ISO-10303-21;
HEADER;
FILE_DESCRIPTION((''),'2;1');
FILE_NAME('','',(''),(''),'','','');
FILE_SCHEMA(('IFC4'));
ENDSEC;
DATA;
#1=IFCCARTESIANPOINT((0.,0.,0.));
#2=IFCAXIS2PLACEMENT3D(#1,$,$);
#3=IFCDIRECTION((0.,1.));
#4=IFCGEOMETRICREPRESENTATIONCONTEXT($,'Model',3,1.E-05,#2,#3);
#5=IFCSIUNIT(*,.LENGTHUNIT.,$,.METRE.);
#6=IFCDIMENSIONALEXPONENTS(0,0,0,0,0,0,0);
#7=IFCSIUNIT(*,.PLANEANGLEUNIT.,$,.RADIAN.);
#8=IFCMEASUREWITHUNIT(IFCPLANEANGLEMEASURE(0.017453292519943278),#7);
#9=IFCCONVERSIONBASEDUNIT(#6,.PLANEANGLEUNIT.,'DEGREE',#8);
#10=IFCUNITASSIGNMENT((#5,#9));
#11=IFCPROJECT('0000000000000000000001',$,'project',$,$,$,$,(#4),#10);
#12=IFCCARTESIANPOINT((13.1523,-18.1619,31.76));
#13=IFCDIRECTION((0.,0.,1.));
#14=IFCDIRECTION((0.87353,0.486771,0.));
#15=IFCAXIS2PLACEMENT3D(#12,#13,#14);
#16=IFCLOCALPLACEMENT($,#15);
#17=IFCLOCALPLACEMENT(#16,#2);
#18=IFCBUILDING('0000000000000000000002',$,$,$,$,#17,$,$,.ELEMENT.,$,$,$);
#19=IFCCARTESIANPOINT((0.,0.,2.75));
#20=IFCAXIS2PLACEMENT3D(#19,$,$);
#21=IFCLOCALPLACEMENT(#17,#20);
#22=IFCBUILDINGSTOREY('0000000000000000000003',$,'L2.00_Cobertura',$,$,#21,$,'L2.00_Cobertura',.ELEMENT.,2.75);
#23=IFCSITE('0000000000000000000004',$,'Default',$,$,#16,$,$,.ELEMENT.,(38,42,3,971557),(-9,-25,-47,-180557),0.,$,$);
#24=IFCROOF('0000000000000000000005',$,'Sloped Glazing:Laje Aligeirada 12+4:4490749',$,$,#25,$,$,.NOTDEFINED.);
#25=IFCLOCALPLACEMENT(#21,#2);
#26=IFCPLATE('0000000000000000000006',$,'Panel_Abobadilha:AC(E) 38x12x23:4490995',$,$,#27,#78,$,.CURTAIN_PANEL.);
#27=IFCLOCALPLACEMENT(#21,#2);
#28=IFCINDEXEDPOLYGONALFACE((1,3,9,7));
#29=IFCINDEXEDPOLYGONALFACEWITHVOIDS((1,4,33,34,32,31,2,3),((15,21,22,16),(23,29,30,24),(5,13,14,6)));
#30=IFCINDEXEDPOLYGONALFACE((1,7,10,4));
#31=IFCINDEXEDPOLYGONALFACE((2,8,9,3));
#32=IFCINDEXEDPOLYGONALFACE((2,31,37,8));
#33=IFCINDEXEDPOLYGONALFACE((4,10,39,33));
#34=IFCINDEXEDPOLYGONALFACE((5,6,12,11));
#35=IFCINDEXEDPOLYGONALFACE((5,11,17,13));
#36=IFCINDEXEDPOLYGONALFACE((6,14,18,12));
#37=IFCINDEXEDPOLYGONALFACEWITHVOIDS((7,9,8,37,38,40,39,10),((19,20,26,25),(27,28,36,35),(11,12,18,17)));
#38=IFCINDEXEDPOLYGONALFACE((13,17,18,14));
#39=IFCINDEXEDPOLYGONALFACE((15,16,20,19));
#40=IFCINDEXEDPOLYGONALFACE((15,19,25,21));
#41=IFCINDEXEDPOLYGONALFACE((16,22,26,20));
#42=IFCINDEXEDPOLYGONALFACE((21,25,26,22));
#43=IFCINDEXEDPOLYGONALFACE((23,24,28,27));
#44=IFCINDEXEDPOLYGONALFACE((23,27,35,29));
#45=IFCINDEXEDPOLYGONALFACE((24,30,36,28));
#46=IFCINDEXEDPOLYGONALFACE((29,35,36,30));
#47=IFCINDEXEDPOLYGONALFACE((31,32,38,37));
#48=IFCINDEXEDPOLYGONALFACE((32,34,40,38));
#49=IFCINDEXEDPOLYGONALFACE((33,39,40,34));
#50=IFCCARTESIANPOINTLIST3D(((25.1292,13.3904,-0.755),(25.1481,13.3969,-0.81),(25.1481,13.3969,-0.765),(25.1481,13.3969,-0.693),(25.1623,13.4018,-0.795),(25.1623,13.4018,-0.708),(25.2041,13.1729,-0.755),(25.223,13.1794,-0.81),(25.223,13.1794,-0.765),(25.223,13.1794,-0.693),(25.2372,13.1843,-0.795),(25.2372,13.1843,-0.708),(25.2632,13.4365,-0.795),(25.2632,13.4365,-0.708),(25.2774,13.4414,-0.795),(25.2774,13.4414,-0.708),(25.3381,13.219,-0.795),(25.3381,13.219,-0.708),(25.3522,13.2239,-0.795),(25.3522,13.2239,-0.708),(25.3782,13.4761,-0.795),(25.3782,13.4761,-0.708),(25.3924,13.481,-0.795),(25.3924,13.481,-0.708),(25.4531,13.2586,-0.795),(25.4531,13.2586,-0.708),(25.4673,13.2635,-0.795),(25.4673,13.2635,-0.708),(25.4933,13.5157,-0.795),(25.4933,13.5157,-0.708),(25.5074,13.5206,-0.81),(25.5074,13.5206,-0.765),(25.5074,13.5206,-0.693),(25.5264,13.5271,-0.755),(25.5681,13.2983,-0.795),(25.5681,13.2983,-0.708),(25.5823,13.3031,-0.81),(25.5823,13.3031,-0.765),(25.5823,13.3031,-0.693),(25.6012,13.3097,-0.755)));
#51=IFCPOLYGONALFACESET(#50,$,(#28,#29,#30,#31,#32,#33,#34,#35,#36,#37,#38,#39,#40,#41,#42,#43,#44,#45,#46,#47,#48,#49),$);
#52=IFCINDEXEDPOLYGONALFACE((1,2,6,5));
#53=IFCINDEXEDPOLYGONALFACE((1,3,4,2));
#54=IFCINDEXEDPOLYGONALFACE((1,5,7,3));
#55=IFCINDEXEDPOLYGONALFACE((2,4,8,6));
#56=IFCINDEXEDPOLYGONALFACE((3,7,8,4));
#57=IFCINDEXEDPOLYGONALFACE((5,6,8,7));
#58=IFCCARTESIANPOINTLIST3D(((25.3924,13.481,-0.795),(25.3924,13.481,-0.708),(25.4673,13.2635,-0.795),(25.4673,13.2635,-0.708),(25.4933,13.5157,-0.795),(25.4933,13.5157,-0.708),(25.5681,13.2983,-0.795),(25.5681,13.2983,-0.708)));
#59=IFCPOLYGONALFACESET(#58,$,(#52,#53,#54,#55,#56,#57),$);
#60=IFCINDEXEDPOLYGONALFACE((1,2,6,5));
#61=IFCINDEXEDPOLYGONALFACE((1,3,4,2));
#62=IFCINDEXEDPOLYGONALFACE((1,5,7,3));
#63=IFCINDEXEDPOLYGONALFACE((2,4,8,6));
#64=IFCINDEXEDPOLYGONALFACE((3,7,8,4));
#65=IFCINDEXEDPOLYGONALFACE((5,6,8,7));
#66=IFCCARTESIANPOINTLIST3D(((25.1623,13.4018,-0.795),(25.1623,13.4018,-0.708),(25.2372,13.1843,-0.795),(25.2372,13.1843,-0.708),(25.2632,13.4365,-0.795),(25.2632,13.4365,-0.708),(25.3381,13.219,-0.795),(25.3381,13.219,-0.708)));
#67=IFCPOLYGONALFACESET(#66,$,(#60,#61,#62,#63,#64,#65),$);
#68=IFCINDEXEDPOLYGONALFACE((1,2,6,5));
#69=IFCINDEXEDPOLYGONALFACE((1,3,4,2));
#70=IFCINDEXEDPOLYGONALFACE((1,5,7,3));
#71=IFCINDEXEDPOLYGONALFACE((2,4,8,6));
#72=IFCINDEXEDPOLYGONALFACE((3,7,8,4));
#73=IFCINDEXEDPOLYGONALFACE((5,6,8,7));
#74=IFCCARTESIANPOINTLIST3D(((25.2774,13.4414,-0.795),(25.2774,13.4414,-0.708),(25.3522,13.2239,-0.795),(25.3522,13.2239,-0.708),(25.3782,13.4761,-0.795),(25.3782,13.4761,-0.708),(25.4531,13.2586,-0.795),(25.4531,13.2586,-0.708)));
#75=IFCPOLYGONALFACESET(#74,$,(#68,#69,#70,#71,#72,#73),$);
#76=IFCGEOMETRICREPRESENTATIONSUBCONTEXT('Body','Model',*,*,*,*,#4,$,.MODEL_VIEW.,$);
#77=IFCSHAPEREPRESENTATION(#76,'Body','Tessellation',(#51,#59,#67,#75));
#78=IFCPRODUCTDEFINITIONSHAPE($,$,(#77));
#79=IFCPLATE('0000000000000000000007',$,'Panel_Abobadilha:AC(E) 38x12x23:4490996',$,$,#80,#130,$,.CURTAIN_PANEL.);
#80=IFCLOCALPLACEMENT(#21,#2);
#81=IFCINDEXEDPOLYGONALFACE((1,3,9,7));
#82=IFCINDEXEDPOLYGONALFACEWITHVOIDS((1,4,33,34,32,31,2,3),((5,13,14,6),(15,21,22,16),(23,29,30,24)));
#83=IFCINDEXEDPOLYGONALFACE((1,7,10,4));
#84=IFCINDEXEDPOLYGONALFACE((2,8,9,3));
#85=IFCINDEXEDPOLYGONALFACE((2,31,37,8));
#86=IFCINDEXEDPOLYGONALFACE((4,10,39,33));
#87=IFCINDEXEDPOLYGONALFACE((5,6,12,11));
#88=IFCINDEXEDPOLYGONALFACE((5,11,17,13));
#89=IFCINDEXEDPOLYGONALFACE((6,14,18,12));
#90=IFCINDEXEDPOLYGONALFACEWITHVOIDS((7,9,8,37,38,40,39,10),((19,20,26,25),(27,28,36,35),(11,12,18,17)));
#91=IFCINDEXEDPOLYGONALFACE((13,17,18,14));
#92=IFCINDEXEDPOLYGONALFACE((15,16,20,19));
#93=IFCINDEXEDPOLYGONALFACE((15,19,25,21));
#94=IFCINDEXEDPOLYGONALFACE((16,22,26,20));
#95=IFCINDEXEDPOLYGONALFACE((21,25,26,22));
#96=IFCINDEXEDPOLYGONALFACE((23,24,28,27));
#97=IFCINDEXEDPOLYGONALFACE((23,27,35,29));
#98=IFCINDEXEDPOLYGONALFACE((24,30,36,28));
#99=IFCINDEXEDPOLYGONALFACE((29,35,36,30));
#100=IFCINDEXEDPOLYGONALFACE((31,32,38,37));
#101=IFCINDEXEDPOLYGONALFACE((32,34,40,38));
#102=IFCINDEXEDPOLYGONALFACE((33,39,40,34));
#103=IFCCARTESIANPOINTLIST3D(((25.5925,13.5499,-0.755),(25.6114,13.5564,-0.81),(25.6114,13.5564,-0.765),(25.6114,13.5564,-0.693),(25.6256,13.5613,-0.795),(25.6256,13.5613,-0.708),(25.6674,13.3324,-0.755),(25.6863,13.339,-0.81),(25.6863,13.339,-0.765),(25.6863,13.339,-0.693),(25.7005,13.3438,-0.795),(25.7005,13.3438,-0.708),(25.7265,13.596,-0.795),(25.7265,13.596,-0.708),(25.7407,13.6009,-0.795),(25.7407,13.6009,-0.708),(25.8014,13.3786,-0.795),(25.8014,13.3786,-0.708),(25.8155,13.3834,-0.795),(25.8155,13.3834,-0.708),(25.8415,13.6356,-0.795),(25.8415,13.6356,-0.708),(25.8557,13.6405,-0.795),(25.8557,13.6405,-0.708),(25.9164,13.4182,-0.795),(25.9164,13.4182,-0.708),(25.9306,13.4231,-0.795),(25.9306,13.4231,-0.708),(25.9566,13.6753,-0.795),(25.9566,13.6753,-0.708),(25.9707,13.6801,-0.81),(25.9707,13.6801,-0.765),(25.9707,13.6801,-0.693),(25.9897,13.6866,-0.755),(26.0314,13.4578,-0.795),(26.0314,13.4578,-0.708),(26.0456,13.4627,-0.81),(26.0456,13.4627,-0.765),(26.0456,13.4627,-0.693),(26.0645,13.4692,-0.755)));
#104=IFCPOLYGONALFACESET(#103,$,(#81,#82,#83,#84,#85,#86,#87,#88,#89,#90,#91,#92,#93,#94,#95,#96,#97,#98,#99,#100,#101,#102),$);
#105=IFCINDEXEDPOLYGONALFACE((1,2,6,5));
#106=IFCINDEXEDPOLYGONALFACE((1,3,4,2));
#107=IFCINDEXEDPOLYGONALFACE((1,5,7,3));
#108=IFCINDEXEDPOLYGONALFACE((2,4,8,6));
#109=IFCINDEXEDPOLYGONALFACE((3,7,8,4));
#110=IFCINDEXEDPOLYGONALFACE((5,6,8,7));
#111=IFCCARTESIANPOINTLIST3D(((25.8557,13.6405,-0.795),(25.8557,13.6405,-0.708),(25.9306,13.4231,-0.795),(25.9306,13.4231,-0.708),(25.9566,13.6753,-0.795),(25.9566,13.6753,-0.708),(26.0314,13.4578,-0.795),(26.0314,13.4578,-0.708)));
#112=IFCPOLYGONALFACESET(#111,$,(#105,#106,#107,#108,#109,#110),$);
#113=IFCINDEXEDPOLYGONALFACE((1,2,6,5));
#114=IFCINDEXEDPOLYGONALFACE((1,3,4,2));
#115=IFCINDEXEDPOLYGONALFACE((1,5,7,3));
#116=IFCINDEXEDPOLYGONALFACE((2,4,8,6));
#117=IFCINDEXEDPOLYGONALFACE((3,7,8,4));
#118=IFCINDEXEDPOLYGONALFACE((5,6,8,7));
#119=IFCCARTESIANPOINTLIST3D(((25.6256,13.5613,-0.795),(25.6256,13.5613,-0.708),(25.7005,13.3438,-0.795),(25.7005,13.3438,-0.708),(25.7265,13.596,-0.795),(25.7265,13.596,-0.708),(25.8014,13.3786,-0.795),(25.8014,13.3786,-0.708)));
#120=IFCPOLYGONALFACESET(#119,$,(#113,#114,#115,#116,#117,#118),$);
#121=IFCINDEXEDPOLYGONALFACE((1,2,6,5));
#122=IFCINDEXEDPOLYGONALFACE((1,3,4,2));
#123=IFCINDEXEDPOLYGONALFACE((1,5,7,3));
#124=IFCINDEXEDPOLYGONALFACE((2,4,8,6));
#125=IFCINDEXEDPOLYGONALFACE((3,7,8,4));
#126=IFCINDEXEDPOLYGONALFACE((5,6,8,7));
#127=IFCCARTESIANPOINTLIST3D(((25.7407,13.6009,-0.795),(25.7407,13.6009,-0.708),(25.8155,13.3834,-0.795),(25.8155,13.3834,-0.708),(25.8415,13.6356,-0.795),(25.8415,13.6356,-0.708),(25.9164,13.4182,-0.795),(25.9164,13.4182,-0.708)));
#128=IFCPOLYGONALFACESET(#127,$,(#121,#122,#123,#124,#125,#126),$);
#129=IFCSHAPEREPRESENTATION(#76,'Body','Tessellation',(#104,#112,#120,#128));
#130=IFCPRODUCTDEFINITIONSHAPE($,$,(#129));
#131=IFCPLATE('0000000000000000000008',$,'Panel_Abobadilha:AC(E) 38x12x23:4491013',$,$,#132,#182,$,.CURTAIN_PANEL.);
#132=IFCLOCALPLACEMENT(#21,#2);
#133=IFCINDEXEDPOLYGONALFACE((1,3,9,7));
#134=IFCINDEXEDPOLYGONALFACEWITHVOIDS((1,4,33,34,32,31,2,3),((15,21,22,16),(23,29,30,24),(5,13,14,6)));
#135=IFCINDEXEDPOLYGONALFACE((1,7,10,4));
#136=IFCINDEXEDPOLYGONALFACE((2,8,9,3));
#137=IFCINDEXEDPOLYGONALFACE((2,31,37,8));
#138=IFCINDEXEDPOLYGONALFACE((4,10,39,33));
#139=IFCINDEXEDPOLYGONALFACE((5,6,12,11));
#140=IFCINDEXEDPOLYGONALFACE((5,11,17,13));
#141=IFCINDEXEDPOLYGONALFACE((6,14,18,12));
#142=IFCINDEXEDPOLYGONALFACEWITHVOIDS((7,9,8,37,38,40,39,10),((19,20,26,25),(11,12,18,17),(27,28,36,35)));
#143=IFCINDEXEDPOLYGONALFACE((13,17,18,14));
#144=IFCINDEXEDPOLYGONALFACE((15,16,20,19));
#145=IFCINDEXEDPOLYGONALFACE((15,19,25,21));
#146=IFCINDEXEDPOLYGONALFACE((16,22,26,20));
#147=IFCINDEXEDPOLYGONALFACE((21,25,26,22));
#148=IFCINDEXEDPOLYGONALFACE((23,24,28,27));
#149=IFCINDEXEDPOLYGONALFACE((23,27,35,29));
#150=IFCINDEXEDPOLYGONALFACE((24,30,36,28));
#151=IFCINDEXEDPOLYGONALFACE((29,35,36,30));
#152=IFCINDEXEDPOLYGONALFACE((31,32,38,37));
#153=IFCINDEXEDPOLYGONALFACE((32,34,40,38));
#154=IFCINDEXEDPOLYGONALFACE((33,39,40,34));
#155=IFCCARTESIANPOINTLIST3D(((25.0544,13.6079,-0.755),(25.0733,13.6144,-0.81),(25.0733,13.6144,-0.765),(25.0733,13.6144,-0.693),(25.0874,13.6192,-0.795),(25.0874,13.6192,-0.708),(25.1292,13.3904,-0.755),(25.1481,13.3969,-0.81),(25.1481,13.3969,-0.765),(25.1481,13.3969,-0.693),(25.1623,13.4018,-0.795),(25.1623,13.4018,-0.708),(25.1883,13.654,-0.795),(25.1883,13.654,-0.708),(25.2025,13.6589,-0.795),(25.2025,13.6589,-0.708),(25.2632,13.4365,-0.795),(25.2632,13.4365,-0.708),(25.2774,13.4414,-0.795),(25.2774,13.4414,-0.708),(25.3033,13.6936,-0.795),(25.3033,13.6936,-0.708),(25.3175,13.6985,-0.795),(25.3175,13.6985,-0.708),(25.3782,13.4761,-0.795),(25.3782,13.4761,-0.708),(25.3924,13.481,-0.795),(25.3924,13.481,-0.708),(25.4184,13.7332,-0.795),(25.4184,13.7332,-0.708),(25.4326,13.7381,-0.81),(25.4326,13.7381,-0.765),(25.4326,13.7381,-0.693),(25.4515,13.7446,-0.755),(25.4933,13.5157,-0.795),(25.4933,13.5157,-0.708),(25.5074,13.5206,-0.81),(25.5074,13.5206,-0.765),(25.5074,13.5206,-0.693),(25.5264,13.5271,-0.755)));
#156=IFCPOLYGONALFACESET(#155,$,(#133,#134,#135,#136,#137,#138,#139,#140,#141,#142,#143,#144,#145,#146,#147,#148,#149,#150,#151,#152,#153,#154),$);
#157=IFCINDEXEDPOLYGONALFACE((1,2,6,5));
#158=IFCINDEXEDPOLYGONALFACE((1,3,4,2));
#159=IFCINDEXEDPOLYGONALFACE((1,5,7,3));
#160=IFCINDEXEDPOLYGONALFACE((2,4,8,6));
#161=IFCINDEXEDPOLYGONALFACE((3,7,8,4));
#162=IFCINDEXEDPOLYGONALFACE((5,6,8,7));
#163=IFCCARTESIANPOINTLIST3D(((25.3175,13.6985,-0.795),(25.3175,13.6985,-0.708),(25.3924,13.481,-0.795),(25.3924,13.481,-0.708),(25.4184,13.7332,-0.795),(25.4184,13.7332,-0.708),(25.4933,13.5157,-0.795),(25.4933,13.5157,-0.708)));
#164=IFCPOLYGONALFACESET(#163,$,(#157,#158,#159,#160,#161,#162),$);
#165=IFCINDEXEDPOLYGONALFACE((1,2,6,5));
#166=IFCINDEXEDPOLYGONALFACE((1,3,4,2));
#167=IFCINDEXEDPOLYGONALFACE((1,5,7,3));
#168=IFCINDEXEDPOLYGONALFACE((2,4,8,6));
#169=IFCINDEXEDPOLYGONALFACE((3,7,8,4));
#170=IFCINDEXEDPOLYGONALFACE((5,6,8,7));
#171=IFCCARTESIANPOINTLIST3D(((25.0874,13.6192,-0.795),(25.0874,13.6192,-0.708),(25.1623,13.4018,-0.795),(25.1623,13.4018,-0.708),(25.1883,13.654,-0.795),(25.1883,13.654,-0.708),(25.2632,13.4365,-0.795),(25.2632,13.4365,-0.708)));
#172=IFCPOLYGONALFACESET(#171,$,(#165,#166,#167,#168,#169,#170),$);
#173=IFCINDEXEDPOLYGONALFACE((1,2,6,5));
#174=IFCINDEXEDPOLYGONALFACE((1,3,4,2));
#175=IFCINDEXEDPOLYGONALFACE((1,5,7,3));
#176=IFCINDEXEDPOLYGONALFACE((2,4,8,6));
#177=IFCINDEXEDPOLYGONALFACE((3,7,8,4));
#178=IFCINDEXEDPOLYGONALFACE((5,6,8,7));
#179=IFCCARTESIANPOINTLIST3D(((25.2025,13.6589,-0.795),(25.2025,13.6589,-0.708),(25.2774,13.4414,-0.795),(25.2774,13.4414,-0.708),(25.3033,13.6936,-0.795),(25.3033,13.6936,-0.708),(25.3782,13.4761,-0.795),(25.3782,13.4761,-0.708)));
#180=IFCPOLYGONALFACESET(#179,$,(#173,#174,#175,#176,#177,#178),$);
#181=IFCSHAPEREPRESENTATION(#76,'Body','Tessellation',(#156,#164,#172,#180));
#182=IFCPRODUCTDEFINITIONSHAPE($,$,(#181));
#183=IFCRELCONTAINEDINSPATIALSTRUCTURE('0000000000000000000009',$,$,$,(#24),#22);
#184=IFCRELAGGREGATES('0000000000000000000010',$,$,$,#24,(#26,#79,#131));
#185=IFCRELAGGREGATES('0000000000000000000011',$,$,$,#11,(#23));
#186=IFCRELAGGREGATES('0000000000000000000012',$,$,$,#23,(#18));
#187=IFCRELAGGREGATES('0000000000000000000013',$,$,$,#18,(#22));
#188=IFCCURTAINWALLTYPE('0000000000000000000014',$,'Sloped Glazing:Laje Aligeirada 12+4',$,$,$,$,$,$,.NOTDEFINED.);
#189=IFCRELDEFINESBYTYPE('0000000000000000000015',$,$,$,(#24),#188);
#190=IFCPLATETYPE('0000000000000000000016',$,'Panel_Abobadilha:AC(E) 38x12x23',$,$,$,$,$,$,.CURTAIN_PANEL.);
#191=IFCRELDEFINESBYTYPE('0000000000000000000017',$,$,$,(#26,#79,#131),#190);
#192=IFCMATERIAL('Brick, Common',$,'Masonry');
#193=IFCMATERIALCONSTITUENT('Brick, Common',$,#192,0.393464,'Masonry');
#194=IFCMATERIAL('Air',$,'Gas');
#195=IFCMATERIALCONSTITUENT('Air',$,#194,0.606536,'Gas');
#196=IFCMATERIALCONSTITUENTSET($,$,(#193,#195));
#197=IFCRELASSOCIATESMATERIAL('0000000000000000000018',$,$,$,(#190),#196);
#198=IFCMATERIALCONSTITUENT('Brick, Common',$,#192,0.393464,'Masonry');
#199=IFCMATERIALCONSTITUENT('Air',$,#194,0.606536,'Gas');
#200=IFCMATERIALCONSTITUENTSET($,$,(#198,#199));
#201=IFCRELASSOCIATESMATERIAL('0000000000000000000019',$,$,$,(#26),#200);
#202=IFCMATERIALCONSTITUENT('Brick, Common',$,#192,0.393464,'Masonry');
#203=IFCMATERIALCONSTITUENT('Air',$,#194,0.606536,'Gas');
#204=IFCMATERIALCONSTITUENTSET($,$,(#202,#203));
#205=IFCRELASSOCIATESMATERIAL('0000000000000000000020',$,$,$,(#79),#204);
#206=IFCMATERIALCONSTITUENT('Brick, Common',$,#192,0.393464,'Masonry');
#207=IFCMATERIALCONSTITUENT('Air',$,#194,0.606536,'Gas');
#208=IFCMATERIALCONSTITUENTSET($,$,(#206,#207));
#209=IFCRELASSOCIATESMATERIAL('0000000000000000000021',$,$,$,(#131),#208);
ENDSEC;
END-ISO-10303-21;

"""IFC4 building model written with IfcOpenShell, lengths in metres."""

from ifc_helpers import new_model, entity, si_unit, converted_unit, direction, frame, origin, place, context, subcontext, project, spatial, indexed_curve, outline, extrude, source, transform, mapped, material, constituent, constituent_set, type_object, type_shapes, element, aggregate, save


model = new_model("IFC4")

# Units and contexts
model_context = context("Model", 3, precision=1e-05, world=origin(), true_north=direction((0.0, 1.0)))
body_context = subcontext(model_context, "Body", "Model", "MODEL_VIEW")
ifc_project = project(units=[si_unit("LENGTHUNIT", "METRE"), converted_unit("PLANEANGLEUNIT", "DEGREE", entity("IfcPlaneAngleMeasure", 0.017453292519943278), si_unit("PLANEANGLEUNIT", "RADIAN"), dimensions=[0, 0, 0, 0, 0, 0, 0])], contexts=[model_context])

# Site, building, storey
site_placement = place(None, frame((13.1523, -18.1619, 31.76), z_axis=(0.0, 0.0, 1.0), x_axis=(0.87353, 0.486771, 0.0)))
site = spatial("IfcSite", under=ifc_project, at=site_placement, Name="Default", CompositionType="ELEMENT", RefLatitude=(38, 42, 3, 971557), RefLongitude=(-9, -25, -47, -180557), RefElevation=0.0)
building_placement = place(site_placement, origin())
building = spatial("IfcBuilding", under=site, at=building_placement, CompositionType="ELEMENT")
storey_placement = place(building_placement, frame((0.0, 0.0, 2.75)))
storey = spatial("IfcBuildingStorey", under=building, at=storey_placement, Name="L2.00_Cobertura", LongName="L2.00_Cobertura", CompositionType="ELEMENT", Elevation=2.75)

# Roof, plates
curtain_wall_type = type_object("IfcCurtainWallType", Name="Sloped Glazing:Laje Aligeirada 12+4", PredefinedType="NOTDEFINED")
roof_placement = place(storey_placement, frame((0.0, 0.0, -2.75)))
roof = element("IfcRoof", 1, at=roof_placement, inside=storey, type_object=curtain_wall_type, Name="Sloped Glazing:Laje Aligeirada 12+4:4490749", PredefinedType="NOTDEFINED")
ifc_material_1 = material(Name="Brick, Common", Category="Masonry")
ifc_material_2 = material(Name="Air", Category="Gas")
ifc_constituent_1 = constituent(ifc_material_1, Name="Brick, Common", Category="Masonry", fraction=0.393464)
ifc_constituent_2 = constituent(ifc_material_2, Name="Air", Category="Gas", fraction=0.606536)
ifc_constituent_set_1 = constituent_set(constituents=[ifc_constituent_1, ifc_constituent_2])
plate_type = type_object("IfcPlateType", Name="Panel_Abobadilha:AC(E) 38x12x23", PredefinedType="CURTAIN_PANEL", material=ifc_constituent_set_1)
shared_shape_1 = source(origin(), body_context, "Body", "SweptSolid", [
    extrude(outline(indexed_curve([(-0.19, -0.0543), (0.19, -0.0543), (0.19, -0.0093), (0.21, 0.0007), (0.19, 0.0628), (-0.19, 0.0628), (-0.21, 0.0007), (-0.19, -0.0093), (-0.19, -0.0543)], self_intersect=False), holes=[indexed_curve([(-0.0683, 0.0477), (-0.0683, -0.0393), (-0.175, -0.0393), (-0.175, 0.0477), (-0.0683, 0.0477)], self_intersect=False), indexed_curve([(0.0533, 0.0477), (0.0533, -0.0393), (-0.0533, -0.0393), (-0.0533, 0.0477), (0.0533, 0.0477)], self_intersect=False), indexed_curve([(0.175, 0.0477), (0.175, -0.0393), (0.0683, -0.0393), (0.0683, 0.0477), (0.175, 0.0477)], self_intersect=False)]), frame((0.0, 0.0543, 0.0)), (0.0, 0.0, 1.0), 0.23),
    extrude(outline(indexed_curve([(-0.0533, -0.0435), (0.0533, -0.0435), (0.0533, 0.0435), (-0.0533, 0.0435), (-0.0533, -0.0435)], self_intersect=False)), frame((0.1217, 0.0585, 0.0), z_axis=(0.0, 0.0, 1.0), x_axis=(-1.0, 0.0, 0.0)), (0.0, 0.0, 1.0), 0.23),
    extrude(outline(indexed_curve([(-0.0533, -0.0435), (0.0533, -0.0435), (0.0533, 0.0435), (-0.0533, 0.0435), (-0.0533, -0.0435)], self_intersect=False)), frame((-0.1217, 0.0585, 0.0), z_axis=(0.0, 0.0, 1.0), x_axis=(-1.0, 0.0, 0.0)), (0.0, 0.0, 1.0), 0.23),
    extrude(outline(indexed_curve([(-0.0533, -0.0435), (0.0533, -0.0435), (0.0533, 0.0435), (-0.0533, 0.0435), (-0.0533, -0.0435)], self_intersect=False)), frame((0.0, 0.0585, 0.0), z_axis=(0.0, 0.0, 1.0), x_axis=(-1.0, 0.0, 0.0)), (0.0, 0.0, 1.0), 0.23),
])
type_shapes(plate_type, [shared_shape_1])
ifc_constituent_3 = constituent(ifc_material_1, Name="Brick, Common", Category="Masonry", fraction=0.393464)
ifc_constituent_4 = constituent(ifc_material_2, Name="Air", Category="Gas", fraction=0.606536)
ifc_constituent_set_2 = constituent_set(constituents=[ifc_constituent_3, ifc_constituent_4])
plate_1_placement = place(roof_placement, frame((25.3278, 13.4588, 1.94), z_axis=(0.325568, -0.945519, 0.0), x_axis=(0.945519, 0.325568, 0.0)))
plate_1 = element("IfcPlate", 2, at=plate_1_placement, type_object=plate_type, material=ifc_constituent_set_2, Name="Panel_Abobadilha:AC(E) 38x12x23:4490995", PredefinedType="CURTAIN_PANEL", context=body_context, shape_type="MappedRepresentation", body=[
    mapped(shared_shape_1, transform((0.0, 0.0, 0.0), scale=1.0)),
])
ifc_constituent_5 = constituent(ifc_material_1, Name="Brick, Common", Category="Masonry", fraction=0.393464)
ifc_constituent_6 = constituent(ifc_material_2, Name="Air", Category="Gas", fraction=0.606536)
ifc_constituent_set_3 = constituent_set(constituents=[ifc_constituent_5, ifc_constituent_6])
plate_2_placement = place(roof_placement, frame((25.7911, 13.6183, 1.94), z_axis=(0.325568, -0.945519, 0.0), x_axis=(0.945519, 0.325568, 0.0)))
plate_2 = element("IfcPlate", 3, at=plate_2_placement, type_object=plate_type, material=ifc_constituent_set_3, Name="Panel_Abobadilha:AC(E) 38x12x23:4490996", PredefinedType="CURTAIN_PANEL", context=body_context, shape_type="MappedRepresentation", body=[
    mapped(shared_shape_1, transform((0.0, 0.0, 0.0), scale=1.0)),
])
ifc_constituent_7 = constituent(ifc_material_1, Name="Brick, Common", Category="Masonry", fraction=0.393464)
ifc_constituent_8 = constituent(ifc_material_2, Name="Air", Category="Gas", fraction=0.606536)
ifc_constituent_set_4 = constituent_set(constituents=[ifc_constituent_7, ifc_constituent_8])
plate_3_placement = place(roof_placement, frame((25.2529, 13.6762, 1.94), z_axis=(0.325568, -0.945519, 0.0), x_axis=(0.945519, 0.325568, 0.0)))
plate_3 = element("IfcPlate", 4, at=plate_3_placement, type_object=plate_type, material=ifc_constituent_set_4, Name="Panel_Abobadilha:AC(E) 38x12x23:4491013", PredefinedType="CURTAIN_PANEL", context=body_context, shape_type="MappedRepresentation", body=[
    mapped(shared_shape_1, transform((0.0, 0.0, 0.0), scale=1.0)),
])
aggregate(roof, [plate_1, plate_2, plate_3])

save(model, "model.ifc")
